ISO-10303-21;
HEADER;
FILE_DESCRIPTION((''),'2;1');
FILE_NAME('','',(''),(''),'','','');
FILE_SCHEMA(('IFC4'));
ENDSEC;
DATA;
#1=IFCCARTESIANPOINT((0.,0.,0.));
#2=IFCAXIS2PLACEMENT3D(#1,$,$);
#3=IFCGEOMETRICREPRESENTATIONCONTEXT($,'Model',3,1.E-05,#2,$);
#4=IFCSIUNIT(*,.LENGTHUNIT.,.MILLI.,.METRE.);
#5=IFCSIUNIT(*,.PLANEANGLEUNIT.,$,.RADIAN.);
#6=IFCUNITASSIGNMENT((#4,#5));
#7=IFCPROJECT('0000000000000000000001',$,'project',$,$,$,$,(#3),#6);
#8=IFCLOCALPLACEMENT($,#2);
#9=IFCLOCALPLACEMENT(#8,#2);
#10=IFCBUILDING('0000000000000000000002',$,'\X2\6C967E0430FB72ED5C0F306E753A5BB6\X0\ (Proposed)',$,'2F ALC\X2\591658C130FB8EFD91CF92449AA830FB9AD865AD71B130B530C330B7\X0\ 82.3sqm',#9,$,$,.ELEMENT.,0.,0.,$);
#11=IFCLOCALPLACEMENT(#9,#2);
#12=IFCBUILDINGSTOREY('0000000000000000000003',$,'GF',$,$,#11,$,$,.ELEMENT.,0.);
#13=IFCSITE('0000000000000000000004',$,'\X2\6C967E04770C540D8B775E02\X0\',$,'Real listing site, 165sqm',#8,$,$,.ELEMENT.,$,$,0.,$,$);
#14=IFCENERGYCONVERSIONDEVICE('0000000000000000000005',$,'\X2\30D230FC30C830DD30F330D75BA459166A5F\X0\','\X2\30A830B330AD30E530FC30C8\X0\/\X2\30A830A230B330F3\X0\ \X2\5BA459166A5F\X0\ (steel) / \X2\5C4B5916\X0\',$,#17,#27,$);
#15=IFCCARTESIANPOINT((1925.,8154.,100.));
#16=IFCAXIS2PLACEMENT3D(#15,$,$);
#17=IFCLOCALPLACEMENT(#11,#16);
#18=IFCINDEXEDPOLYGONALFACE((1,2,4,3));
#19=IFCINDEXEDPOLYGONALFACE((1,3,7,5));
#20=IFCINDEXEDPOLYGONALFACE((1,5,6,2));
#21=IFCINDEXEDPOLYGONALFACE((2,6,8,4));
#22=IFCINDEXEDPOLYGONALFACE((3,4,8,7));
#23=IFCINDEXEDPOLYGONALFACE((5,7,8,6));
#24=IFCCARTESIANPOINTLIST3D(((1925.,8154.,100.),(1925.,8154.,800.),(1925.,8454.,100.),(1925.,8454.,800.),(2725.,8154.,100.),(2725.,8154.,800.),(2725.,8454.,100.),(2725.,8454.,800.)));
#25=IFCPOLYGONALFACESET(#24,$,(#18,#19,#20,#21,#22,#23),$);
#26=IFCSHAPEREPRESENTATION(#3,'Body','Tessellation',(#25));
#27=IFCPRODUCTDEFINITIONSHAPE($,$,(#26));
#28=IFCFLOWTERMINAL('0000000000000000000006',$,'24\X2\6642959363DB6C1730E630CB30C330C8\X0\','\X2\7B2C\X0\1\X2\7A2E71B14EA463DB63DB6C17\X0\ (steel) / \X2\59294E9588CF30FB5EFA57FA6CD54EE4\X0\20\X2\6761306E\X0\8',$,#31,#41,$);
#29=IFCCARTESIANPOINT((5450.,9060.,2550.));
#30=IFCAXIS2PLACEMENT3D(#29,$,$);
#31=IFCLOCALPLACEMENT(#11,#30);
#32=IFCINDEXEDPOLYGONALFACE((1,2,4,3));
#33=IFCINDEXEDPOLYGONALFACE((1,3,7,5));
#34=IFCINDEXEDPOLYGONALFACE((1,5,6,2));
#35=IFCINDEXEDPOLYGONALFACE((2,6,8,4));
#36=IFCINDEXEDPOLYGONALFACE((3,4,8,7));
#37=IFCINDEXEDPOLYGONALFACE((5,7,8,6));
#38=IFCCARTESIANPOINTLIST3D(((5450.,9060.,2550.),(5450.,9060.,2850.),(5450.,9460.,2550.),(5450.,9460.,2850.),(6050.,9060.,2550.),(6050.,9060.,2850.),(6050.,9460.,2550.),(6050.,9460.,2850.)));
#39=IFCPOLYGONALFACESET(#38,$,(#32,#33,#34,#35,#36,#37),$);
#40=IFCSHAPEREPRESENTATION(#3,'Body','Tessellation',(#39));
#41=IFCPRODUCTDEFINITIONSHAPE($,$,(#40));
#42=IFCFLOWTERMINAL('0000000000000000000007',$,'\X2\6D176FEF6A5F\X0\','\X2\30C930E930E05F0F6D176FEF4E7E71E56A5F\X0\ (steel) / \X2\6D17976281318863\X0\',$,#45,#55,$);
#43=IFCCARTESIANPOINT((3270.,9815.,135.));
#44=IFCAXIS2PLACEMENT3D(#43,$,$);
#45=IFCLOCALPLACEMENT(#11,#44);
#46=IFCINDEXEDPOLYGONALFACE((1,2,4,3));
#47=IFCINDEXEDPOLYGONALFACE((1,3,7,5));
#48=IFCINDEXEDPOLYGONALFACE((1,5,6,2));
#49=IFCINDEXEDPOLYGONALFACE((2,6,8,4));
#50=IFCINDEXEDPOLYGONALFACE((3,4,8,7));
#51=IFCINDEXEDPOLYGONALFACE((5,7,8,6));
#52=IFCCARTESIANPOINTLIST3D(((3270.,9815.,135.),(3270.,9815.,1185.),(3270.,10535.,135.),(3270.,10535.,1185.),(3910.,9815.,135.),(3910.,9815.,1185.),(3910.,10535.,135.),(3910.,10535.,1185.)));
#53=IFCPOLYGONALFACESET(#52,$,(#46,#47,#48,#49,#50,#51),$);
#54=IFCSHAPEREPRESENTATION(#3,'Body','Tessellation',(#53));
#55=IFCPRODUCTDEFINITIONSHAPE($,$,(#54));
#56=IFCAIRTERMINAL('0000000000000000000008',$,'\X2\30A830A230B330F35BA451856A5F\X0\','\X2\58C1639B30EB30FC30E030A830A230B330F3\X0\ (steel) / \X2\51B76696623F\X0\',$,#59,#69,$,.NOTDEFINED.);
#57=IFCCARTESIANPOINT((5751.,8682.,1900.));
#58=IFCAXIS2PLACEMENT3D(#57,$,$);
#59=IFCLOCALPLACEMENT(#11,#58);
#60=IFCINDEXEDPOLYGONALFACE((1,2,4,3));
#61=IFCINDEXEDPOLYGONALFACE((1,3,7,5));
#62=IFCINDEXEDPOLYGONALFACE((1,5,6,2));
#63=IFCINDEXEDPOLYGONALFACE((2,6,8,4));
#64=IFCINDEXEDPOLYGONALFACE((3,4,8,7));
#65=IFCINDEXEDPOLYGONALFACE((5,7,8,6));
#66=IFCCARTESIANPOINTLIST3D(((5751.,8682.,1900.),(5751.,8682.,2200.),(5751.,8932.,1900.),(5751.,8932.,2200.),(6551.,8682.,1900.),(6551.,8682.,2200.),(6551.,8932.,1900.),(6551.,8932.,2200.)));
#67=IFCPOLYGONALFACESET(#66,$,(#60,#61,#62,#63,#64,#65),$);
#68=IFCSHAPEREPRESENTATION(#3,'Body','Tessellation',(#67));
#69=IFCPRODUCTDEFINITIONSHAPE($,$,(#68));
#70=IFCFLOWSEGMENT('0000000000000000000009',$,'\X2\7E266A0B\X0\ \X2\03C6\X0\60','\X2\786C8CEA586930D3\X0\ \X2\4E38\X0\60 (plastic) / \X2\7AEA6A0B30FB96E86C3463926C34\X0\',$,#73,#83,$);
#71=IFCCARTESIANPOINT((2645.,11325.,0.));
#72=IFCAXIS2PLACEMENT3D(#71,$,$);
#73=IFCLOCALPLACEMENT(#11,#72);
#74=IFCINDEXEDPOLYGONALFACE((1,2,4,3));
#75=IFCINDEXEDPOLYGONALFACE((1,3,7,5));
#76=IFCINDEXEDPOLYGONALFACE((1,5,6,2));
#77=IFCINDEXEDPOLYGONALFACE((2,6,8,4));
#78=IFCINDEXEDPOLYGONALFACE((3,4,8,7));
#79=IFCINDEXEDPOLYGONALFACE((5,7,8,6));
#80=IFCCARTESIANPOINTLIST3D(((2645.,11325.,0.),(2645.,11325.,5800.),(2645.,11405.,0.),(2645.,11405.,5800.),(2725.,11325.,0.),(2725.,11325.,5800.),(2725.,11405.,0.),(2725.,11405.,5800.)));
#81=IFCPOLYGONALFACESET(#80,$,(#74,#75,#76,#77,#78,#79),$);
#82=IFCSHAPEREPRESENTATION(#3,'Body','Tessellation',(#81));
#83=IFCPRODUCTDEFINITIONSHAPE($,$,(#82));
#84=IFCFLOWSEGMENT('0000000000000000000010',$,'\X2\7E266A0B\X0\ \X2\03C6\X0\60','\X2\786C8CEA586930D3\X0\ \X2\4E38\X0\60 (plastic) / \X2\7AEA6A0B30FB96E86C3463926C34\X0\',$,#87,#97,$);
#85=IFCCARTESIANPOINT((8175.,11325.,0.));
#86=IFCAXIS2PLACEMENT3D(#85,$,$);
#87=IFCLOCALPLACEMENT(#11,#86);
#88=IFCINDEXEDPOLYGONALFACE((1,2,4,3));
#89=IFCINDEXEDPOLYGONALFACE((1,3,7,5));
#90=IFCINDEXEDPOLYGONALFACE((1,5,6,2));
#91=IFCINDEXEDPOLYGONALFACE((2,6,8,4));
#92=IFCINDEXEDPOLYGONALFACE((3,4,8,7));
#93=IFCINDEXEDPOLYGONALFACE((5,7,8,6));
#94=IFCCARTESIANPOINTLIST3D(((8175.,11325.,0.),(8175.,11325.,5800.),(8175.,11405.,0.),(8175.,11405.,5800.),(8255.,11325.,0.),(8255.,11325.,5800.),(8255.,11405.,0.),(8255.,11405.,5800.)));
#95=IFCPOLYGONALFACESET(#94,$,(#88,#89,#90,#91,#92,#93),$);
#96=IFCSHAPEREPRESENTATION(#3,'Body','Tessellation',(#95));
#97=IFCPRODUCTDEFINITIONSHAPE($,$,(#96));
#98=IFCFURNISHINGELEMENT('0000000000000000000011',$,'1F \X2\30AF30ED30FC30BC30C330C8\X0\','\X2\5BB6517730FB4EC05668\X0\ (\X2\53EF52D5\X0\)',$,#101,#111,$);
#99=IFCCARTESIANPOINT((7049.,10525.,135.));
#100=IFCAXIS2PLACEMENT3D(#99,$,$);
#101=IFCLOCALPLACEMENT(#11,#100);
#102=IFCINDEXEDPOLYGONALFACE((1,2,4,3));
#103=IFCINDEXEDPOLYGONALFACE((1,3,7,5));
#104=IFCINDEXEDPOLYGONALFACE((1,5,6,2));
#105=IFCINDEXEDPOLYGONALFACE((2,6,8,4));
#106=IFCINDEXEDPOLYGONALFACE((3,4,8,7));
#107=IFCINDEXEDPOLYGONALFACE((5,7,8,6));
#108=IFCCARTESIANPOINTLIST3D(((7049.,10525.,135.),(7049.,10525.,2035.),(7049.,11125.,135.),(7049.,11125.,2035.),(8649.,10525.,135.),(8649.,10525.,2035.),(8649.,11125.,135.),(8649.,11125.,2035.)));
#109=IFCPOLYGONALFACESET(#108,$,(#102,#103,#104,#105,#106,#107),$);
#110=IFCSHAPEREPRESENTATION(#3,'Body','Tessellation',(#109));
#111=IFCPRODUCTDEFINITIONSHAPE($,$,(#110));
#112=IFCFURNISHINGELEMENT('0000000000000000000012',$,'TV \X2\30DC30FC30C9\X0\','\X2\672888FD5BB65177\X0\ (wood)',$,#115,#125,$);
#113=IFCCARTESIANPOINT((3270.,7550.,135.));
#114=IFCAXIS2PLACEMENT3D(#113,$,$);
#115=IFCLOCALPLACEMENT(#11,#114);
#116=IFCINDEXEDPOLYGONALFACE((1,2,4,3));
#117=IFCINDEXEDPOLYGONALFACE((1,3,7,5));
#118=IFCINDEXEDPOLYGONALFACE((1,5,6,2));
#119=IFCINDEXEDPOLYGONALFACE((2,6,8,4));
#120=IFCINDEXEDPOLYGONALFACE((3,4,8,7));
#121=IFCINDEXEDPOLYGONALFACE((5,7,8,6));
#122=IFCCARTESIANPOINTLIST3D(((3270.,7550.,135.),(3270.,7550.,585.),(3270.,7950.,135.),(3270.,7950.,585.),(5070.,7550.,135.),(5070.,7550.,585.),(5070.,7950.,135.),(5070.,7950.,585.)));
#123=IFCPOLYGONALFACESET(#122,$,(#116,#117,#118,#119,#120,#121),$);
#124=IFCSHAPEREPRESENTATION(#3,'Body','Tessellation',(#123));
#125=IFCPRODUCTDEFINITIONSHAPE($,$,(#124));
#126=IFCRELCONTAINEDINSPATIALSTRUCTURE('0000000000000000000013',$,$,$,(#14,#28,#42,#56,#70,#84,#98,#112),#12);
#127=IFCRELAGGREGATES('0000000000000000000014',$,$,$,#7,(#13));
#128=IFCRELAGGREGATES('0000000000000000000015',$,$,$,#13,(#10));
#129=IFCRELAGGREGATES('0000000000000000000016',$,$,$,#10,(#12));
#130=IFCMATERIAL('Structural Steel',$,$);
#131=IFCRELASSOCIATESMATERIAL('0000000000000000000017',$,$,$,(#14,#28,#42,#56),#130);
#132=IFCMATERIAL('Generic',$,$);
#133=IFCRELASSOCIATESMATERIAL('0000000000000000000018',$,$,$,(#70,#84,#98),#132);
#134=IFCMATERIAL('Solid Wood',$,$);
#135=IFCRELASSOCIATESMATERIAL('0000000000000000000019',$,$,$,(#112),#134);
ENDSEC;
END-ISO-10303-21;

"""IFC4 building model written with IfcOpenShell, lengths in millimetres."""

from ifc_helpers import new_model, si_unit, frame, frame_2d, origin, place, context, project, spatial, rectangle, extrude, material, element, save


model = new_model("IFC4")

# Units and contexts
model_context = context("Model", 3, precision=1e-05, world=origin())
ifc_project = project(units=[si_unit("LENGTHUNIT", "METRE", prefix="MILLI"), si_unit("PLANEANGLEUNIT", "RADIAN")], contexts=[model_context])

# Site, building, storey
site_placement = place(None, origin())
site = spatial("IfcSite", under=ifc_project, at=site_placement, Name="沖縄県名護市", ObjectType="Real listing site, 165sqm", CompositionType="ELEMENT", RefElevation=0.0)
building_placement = place(site_placement, origin())
building = spatial("IfcBuilding", under=site, at=building_placement, Name="沖縄・狭小の町家 (Proposed)", ObjectType="2F ALC外壁・軽量鉄骨・高断熱サッシ 82.3sqm", CompositionType="ELEMENT", ElevationOfRefHeight=0.0, ElevationOfTerrain=0.0)
storey_placement = place(building_placement, origin())
storey = spatial("IfcBuildingStorey", under=building, at=storey_placement, Name="GF", CompositionType="ELEMENT", Elevation=0.0)

# Shared definitions
ifc_material_1 = material(Name="Solid Wood")

# Shared definitions
ifc_material_2 = material(Name="Generic")

# Shared definitions
ifc_material_3 = material(Name="Structural Steel")

# Energy conversion device
energy_conversion_device_placement = place(storey_placement, frame((1925.0, 8154.0, 100.0)))
element("IfcEnergyConversionDevice", 1, at=energy_conversion_device_placement, inside=storey, material=ifc_material_3, Name="ヒートポンプ室外機", Description="エコキュート/エアコン 室外機 (steel) / 屋外", context=model_context, shape_type="SweptSolid", body=[
    extrude(rectangle(XDim=800.0, YDim=300.0, at=frame_2d((400.0, 150.0))), frame((1925.0, 8154.0, 100.0)), (0.0, 0.0, 1.0), 700.0),
])

# Flow terminals
flow_terminal_1_placement = place(storey_placement, frame((5450.0, 9060.0, 2550.0)))
element("IfcFlowTerminal", 2, at=flow_terminal_1_placement, inside=storey, material=ifc_material_3, Name="24時間換気ユニット", Description="第1種熱交換換気 (steel) / 天井裏・建基法令20条の8", context=model_context, shape_type="SweptSolid", body=[
    extrude(rectangle(XDim=600.0, YDim=400.0, at=frame_2d((300.0, 200.0))), frame((5450.0, 9060.0, 2550.0)), (0.0, 0.0, 1.0), 300.0),
])
flow_terminal_2_placement = place(storey_placement, frame((3270.0, 9815.0, 135.0)))
element("IfcFlowTerminal", 3, at=flow_terminal_2_placement, inside=storey, material=ifc_material_3, Name="洗濯機", Description="ドラム式洗濯乾燥機 (steel) / 洗面脱衣", context=model_context, shape_type="SweptSolid", body=[
    extrude(rectangle(XDim=640.0, YDim=720.0, at=frame_2d((320.0, 360.0))), frame((3270.0, 9815.0, 135.0)), (0.0, 0.0, 1.0), 1050.0),
])

# Air terminal
air_terminal_placement = place(storey_placement, frame((5751.0, 8682.0, 1900.0)))
element("IfcAirTerminal", 4, at=air_terminal_placement, inside=storey, material=ifc_material_3, Name="エアコン室内機", Description="壁掛ルームエアコン (steel) / 冷暖房", PredefinedType="NOTDEFINED", context=model_context, shape_type="SweptSolid", body=[
    extrude(rectangle(XDim=800.0, YDim=250.0, at=frame_2d((400.0, 125.0))), frame((5751.0, 8682.0, 1900.0)), (0.0, 0.0, 1.0), 300.0),
])

# Flow segments
flow_segment_1_placement = place(storey_placement, frame((2645.0, 11325.0, 0.0)))
element("IfcFlowSegment", 5, at=flow_segment_1_placement, inside=storey, material=ifc_material_2, Name="縦樋 φ60", Description="硬質塩ビ 丸60 (plastic) / 竪樋・雨水排水", context=model_context, shape_type="SweptSolid", body=[
    extrude(rectangle(XDim=80.0, YDim=80.0, at=frame_2d((40.0, 40.0))), frame((2645.0, 11325.0, 0.0)), (0.0, 0.0, 1.0), 5800.0),
])
flow_segment_2_placement = place(storey_placement, frame((8175.0, 11325.0, 0.0)))
element("IfcFlowSegment", 6, at=flow_segment_2_placement, inside=storey, material=ifc_material_2, Name="縦樋 φ60", Description="硬質塩ビ 丸60 (plastic) / 竪樋・雨水排水", context=model_context, shape_type="SweptSolid", body=[
    extrude(rectangle(XDim=80.0, YDim=80.0, at=frame_2d((40.0, 40.0))), frame((8175.0, 11325.0, 0.0)), (0.0, 0.0, 1.0), 5800.0),
])

# Furnishing elements
furnishing_1_placement = place(storey_placement, frame((7049.0, 10525.0, 135.0)))
element("IfcFurnishingElement", 7, at=furnishing_1_placement, inside=storey, material=ifc_material_2, Name="1F クローゼット", Description="家具・什器 (可動)", context=model_context, shape_type="SweptSolid", body=[
    extrude(rectangle(XDim=1600.0, YDim=600.0, at=frame_2d((800.0, 300.0))), frame((7049.0, 10525.0, 135.0)), (0.0, 0.0, 1.0), 1900.0),
])
furnishing_2_placement = place(storey_placement, frame((3270.0, 7550.0, 135.0)))
element("IfcFurnishingElement", 8, at=furnishing_2_placement, inside=storey, material=ifc_material_1, Name="TV ボード", Description="木製家具 (wood)", context=model_context, shape_type="SweptSolid", body=[
    extrude(rectangle(XDim=1800.0, YDim=400.0, at=frame_2d((900.0, 200.0))), frame((3270.0, 7550.0, 135.0)), (0.0, 0.0, 1.0), 450.0),
])

save(model, "model.ifc")
